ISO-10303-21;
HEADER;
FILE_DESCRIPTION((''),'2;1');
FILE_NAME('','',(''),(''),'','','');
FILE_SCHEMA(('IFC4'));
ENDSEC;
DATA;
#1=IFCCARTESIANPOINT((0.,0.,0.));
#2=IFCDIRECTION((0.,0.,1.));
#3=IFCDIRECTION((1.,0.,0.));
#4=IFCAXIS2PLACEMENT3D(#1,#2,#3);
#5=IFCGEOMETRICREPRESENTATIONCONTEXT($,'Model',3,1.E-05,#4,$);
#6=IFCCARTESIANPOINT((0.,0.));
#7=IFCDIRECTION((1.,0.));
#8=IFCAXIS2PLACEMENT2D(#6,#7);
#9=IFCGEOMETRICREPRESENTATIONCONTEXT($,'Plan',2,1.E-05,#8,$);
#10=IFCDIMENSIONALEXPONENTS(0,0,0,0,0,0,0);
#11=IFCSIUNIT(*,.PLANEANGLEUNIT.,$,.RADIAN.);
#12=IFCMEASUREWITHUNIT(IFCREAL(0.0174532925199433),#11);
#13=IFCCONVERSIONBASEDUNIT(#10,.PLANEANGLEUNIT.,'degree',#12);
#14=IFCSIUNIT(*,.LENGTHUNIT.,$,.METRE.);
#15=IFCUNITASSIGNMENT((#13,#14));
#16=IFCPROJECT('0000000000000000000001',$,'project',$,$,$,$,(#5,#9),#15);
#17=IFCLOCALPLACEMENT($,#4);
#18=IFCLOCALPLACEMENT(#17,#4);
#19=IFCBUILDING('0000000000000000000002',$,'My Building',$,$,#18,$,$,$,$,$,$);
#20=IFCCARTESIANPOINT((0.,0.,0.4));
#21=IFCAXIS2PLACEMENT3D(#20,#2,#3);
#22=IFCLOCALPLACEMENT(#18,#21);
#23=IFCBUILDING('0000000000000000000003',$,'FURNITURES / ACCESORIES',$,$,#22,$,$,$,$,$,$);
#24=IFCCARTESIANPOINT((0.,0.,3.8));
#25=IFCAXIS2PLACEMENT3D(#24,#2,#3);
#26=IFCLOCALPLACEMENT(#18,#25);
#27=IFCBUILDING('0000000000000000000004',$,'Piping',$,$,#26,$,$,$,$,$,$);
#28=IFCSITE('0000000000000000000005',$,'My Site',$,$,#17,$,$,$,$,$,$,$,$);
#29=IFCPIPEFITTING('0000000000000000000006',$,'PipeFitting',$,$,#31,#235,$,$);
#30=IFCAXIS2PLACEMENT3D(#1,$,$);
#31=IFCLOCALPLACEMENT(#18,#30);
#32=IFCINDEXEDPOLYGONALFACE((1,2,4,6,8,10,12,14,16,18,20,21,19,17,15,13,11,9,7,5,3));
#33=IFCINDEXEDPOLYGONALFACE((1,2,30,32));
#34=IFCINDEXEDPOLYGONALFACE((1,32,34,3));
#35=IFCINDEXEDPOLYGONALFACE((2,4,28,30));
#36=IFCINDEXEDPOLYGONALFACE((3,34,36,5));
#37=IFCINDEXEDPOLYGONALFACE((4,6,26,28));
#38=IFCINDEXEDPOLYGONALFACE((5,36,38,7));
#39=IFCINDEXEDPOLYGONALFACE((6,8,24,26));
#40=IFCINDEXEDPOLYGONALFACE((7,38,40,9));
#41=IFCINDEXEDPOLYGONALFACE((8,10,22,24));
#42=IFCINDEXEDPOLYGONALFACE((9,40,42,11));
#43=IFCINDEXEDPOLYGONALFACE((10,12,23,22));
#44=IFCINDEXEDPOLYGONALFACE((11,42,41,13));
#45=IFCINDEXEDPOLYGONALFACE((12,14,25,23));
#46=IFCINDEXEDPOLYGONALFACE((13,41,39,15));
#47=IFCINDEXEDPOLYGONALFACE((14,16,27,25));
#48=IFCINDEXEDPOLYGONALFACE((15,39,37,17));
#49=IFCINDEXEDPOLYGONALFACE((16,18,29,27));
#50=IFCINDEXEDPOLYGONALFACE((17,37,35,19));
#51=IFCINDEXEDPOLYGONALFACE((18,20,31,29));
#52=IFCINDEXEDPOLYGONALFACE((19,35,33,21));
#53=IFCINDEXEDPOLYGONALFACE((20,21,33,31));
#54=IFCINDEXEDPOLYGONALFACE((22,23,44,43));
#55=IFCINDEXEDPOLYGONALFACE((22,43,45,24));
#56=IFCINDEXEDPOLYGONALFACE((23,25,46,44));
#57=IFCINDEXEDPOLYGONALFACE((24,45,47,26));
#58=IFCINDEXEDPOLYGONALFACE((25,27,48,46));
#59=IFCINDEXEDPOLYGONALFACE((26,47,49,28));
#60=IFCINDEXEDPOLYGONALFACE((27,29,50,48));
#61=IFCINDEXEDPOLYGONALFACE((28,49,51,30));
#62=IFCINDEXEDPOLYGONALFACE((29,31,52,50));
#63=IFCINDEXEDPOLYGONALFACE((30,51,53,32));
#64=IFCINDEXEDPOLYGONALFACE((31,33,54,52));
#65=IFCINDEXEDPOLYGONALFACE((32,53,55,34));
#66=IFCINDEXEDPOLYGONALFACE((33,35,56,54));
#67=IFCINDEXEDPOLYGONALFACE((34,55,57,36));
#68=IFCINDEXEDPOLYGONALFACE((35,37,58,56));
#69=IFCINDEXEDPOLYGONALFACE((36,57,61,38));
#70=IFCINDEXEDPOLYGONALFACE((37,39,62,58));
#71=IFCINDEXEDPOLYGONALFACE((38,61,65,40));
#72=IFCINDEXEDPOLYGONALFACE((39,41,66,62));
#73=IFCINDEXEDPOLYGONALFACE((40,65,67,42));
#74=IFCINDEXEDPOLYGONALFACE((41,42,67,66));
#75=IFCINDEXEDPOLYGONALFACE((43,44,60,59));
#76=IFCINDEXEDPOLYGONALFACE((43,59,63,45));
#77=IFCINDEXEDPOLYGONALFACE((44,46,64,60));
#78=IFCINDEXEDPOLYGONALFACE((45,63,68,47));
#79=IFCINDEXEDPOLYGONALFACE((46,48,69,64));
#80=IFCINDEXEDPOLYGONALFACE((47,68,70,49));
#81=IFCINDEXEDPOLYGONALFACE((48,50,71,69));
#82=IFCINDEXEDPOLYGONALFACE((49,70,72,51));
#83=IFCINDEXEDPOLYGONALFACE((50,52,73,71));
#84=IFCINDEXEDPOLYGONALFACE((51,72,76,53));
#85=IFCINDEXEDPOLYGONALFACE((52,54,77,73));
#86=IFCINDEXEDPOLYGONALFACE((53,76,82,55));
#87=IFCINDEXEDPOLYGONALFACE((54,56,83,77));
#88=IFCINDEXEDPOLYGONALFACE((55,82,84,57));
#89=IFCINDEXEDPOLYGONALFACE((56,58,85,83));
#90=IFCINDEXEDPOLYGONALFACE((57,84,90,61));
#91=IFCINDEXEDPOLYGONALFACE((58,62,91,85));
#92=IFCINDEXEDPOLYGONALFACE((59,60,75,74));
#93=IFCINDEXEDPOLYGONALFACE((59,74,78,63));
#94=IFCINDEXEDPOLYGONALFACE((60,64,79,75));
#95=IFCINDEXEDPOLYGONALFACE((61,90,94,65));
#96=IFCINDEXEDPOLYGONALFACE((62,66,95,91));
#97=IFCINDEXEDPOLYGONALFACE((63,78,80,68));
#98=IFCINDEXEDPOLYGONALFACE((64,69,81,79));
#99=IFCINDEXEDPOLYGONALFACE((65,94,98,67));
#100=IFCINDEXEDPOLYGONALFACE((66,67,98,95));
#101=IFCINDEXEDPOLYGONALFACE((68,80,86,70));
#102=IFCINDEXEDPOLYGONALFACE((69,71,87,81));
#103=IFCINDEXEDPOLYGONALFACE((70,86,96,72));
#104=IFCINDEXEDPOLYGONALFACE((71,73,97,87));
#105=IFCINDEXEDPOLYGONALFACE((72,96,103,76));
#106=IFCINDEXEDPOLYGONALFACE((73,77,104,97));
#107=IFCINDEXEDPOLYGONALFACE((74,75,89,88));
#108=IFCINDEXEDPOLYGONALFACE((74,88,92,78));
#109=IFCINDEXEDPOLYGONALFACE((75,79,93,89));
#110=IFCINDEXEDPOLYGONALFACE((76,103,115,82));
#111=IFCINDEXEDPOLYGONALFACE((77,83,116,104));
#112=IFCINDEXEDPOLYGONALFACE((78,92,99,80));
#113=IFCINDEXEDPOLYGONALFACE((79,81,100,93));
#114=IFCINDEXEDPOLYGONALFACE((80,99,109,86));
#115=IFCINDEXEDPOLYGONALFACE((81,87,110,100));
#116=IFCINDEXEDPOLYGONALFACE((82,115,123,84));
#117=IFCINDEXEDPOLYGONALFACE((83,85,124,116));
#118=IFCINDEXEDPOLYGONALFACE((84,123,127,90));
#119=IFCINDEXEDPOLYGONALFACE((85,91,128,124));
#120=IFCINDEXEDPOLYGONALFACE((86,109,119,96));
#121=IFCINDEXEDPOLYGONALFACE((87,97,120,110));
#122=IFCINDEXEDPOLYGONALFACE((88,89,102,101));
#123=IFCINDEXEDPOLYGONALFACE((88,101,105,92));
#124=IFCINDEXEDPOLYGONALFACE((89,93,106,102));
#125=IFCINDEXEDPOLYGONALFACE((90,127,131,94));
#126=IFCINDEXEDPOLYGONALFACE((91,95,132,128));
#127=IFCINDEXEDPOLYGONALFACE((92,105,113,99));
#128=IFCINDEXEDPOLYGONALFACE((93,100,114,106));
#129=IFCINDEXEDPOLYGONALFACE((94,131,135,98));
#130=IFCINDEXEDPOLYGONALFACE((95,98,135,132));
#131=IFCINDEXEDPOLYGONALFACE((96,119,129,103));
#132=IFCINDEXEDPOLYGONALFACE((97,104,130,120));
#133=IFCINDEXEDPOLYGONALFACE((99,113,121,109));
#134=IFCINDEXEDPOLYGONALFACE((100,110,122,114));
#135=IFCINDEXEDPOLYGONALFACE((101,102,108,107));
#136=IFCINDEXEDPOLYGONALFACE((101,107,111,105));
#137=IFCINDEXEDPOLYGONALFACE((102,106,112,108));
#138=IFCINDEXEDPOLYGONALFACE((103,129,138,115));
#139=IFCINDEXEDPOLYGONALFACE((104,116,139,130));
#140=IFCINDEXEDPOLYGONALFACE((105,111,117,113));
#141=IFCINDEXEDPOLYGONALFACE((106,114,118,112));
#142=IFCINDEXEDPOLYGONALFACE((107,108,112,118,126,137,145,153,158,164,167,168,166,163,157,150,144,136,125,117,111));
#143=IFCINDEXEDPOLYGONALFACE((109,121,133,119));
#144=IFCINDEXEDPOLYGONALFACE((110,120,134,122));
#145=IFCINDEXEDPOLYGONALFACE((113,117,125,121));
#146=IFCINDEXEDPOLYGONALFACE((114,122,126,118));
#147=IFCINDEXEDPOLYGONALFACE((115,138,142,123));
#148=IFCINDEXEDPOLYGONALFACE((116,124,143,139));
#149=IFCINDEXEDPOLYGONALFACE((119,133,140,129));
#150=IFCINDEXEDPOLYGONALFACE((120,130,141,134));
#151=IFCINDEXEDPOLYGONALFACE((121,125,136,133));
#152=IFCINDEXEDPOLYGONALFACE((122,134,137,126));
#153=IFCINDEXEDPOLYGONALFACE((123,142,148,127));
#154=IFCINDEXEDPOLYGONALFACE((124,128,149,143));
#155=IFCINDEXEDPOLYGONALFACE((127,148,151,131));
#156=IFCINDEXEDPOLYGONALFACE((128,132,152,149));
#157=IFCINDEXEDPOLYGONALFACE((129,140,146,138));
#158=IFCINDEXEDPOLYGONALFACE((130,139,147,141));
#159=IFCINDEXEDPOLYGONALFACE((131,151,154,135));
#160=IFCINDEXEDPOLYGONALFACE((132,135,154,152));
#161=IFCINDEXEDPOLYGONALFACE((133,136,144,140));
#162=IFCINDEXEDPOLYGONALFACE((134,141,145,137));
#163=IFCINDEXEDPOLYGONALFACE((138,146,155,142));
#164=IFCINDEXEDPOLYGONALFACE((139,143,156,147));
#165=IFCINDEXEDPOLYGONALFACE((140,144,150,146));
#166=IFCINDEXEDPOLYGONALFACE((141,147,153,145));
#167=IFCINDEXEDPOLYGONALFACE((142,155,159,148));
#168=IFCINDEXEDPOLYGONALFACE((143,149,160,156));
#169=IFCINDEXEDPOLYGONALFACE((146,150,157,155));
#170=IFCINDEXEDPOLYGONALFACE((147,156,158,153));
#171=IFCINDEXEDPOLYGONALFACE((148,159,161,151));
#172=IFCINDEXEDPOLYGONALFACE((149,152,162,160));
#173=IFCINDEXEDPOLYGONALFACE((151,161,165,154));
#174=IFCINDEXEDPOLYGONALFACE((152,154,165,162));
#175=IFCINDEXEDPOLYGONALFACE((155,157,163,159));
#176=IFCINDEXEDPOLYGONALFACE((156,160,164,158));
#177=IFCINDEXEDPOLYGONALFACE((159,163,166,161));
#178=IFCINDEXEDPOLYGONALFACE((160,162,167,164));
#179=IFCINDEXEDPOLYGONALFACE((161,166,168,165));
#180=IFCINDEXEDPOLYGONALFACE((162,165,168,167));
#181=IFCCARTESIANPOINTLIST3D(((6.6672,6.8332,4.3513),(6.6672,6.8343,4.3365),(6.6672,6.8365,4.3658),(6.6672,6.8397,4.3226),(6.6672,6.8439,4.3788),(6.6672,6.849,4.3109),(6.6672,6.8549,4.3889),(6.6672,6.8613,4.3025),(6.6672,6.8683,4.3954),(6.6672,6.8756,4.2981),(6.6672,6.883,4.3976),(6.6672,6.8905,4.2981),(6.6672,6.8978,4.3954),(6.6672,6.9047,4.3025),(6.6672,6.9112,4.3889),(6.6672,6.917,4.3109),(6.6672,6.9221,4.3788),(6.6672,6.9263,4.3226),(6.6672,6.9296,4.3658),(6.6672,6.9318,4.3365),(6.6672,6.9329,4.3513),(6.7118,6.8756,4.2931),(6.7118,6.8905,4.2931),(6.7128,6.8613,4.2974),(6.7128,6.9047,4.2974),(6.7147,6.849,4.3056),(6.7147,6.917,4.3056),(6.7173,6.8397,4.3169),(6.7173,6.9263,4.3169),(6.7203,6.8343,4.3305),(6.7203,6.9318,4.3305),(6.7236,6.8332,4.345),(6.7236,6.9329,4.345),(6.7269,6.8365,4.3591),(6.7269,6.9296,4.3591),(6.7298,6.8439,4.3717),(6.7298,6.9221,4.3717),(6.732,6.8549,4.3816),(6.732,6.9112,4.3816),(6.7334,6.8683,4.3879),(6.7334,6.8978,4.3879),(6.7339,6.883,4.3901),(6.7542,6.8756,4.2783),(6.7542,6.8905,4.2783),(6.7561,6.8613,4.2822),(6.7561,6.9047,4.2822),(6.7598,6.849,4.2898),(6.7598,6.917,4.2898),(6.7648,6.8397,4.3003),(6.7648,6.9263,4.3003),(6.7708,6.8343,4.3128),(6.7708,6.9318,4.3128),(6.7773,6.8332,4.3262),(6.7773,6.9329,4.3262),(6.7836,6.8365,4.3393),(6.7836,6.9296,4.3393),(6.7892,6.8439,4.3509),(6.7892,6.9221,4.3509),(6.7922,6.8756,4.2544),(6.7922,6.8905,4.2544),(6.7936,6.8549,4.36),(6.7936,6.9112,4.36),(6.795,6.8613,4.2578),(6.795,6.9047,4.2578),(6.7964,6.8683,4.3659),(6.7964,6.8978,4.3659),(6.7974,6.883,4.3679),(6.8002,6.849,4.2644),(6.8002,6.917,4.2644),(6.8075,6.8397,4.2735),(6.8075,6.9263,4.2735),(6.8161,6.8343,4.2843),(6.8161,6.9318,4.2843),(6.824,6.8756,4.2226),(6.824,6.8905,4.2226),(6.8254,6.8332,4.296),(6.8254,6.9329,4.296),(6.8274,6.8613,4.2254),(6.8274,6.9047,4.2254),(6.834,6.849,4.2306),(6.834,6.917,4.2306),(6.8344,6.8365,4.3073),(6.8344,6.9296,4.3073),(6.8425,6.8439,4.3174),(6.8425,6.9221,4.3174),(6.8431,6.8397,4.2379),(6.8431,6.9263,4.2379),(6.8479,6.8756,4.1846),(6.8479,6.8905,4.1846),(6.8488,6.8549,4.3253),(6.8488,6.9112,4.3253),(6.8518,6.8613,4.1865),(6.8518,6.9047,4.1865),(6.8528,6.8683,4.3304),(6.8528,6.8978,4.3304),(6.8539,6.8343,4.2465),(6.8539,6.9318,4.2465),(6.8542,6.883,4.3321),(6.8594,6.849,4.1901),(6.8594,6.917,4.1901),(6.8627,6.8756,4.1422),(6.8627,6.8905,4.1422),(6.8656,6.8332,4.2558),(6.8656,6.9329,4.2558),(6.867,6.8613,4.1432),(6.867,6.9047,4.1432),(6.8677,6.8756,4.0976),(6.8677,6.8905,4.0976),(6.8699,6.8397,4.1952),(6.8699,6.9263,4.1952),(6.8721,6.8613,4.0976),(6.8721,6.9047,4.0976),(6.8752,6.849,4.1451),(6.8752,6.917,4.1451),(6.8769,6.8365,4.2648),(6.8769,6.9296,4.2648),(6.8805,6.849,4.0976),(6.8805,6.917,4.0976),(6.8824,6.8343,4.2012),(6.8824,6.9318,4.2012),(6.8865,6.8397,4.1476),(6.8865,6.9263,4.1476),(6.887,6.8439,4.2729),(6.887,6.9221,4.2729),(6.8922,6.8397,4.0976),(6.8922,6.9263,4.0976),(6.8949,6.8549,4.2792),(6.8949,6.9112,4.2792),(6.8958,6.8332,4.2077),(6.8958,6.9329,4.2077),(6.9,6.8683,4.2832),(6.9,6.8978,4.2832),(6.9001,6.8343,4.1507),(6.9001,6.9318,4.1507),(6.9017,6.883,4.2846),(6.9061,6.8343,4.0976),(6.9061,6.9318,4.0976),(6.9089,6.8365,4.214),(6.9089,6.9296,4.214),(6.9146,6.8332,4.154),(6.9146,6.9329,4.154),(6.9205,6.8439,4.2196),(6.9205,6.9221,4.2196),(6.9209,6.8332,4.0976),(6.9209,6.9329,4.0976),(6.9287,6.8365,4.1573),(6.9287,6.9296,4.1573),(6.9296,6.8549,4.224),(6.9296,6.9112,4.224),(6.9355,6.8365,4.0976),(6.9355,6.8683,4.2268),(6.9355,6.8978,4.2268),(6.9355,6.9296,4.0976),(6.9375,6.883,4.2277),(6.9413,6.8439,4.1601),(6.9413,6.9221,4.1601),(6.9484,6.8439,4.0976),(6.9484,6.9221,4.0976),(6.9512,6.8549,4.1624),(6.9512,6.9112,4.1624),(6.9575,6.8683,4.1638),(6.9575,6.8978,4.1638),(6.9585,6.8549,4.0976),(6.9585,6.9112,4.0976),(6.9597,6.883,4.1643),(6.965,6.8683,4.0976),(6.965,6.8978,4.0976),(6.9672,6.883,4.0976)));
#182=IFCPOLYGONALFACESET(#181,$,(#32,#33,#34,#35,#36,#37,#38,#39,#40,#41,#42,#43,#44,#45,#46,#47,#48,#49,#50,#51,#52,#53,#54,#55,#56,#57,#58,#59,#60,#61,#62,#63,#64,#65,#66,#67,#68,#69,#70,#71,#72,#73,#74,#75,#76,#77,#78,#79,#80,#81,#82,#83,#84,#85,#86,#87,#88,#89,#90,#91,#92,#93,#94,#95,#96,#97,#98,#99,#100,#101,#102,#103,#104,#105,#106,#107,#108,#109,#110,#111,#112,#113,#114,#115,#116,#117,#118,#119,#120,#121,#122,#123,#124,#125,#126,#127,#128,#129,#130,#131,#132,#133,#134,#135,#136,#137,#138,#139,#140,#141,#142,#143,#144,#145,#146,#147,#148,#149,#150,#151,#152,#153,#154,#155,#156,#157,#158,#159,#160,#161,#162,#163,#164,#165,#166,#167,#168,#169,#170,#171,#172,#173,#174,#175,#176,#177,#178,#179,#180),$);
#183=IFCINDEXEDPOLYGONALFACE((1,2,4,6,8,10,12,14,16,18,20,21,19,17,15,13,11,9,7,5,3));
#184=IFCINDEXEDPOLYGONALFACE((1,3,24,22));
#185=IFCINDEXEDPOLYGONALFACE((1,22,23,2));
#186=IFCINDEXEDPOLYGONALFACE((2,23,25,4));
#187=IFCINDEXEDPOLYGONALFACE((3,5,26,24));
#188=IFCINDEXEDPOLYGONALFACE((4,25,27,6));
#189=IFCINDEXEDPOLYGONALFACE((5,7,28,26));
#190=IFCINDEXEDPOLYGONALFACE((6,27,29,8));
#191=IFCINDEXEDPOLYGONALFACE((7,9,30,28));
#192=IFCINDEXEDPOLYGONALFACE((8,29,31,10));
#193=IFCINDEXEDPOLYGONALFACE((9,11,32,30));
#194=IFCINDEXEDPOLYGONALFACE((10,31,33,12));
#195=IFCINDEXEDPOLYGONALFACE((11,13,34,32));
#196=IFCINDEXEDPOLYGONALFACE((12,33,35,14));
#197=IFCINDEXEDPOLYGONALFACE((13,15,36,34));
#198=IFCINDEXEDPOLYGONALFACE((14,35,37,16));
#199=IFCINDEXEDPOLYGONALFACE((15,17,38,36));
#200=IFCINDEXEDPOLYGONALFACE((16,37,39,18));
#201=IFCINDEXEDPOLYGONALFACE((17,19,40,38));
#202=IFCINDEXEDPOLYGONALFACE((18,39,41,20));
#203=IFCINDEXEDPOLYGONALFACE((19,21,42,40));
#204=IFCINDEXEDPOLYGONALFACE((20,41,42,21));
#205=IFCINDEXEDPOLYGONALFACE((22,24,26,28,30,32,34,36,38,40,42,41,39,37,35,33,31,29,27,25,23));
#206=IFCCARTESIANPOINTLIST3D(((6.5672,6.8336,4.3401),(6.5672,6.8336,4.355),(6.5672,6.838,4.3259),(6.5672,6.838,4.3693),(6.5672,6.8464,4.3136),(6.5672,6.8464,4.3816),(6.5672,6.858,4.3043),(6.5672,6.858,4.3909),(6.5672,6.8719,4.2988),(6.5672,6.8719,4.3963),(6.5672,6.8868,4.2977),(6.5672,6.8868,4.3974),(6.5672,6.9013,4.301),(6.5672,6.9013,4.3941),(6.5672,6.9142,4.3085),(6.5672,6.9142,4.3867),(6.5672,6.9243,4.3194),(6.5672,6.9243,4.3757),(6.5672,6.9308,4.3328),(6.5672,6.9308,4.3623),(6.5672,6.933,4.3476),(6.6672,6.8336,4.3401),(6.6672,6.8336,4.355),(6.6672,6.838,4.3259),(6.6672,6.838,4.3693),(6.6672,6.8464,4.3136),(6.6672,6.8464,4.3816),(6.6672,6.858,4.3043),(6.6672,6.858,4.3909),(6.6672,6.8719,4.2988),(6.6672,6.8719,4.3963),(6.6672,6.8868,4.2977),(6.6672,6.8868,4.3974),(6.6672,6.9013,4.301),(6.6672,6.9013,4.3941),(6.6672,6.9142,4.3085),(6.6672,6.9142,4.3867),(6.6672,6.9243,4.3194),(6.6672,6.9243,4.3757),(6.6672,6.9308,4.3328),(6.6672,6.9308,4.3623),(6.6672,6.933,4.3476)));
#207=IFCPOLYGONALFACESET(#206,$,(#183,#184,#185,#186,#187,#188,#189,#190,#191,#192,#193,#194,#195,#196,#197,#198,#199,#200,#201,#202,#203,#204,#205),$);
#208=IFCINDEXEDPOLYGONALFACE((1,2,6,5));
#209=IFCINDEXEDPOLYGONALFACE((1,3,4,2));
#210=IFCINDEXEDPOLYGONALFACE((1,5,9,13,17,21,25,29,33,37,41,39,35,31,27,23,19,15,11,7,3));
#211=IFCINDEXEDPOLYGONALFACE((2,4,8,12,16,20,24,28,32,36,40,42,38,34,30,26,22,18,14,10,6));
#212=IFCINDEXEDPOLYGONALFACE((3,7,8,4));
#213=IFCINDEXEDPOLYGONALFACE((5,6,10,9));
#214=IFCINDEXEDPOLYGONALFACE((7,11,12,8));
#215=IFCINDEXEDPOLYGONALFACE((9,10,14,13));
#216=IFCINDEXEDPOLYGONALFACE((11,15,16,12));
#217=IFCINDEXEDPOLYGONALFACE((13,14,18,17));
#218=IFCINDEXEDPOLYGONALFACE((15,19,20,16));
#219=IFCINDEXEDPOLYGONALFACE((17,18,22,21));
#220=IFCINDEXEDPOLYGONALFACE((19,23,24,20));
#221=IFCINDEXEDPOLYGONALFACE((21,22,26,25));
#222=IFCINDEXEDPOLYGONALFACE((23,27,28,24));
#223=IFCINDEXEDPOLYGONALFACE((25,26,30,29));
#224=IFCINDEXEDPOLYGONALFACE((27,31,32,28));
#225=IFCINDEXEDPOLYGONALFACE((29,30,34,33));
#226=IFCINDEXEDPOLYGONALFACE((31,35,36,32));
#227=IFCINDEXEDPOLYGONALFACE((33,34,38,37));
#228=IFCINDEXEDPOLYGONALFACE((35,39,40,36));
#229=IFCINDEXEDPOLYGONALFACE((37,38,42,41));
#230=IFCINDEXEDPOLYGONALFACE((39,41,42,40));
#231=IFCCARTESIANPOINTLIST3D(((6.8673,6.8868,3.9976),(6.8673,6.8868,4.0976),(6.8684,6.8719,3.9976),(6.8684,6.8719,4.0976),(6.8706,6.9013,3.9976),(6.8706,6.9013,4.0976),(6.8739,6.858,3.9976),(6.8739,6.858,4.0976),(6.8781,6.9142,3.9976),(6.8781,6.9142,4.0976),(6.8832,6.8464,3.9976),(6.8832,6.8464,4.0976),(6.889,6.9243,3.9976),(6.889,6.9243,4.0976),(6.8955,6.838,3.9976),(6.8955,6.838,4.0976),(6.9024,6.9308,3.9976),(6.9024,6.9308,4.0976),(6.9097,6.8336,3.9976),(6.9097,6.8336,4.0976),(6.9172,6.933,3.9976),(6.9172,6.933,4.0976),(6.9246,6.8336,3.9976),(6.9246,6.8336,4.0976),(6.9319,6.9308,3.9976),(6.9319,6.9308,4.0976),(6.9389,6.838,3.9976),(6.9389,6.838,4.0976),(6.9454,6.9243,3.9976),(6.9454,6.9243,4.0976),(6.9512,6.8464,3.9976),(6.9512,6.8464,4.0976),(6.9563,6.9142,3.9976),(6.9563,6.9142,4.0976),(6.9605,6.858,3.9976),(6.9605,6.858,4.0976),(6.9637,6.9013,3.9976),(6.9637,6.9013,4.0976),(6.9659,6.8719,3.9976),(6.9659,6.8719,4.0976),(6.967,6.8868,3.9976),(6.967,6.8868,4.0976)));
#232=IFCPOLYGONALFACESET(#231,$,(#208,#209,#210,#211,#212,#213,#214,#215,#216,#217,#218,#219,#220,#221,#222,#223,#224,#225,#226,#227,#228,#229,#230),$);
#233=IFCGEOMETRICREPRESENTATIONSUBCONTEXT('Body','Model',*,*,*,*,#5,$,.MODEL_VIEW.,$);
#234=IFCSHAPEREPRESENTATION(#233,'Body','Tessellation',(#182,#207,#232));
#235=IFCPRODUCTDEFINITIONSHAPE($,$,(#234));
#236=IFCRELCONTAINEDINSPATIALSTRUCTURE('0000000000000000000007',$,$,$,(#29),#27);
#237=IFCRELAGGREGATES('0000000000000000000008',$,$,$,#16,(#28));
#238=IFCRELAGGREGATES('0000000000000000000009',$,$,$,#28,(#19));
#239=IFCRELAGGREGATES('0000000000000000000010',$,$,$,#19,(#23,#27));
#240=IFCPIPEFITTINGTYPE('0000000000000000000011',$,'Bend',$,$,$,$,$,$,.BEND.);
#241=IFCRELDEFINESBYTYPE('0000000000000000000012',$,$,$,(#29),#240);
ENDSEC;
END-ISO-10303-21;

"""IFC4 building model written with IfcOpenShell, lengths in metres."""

from ifc_helpers import new_model, entity, si_unit, converted_unit, frame, origin_with_axes, origin_2d_with_axis, place, context, subcontext, project, spatial, circle, extrude, source, transform, mapped, type_object, type_shapes, element, save


model = new_model("IFC4")

# Units and contexts
model_context = context("Model", 3, precision=1e-05, world=origin_with_axes())
plan_context = context("Plan", 2, precision=1e-05, world=origin_2d_with_axis())
body_context = subcontext(model_context, "Body", "Model", "MODEL_VIEW")
ifc_project = project(units=[converted_unit("PLANEANGLEUNIT", "degree", entity("IfcReal", 0.0174532925199433), si_unit("PLANEANGLEUNIT", "RADIAN"), dimensions=[0, 0, 0, 0, 0, 0, 0]), si_unit("LENGTHUNIT", "METRE")], contexts=[model_context, plan_context])

# Site, building
site_placement = place(None, origin_with_axes())
site = spatial("IfcSite", under=ifc_project, at=site_placement, Name="My Site")
building_1_placement = place(site_placement, origin_with_axes())
building_1 = spatial("IfcBuilding", under=site, at=building_1_placement, Name="My Building")

# Shared definitions
building_2_placement = place(building_1_placement, frame((0.0, 0.0, 0.4), z_axis=(0.0, 0.0, 1.0), x_axis=(1.0, 0.0, 0.0)))
building_2 = spatial("IfcBuilding", under=building_1, at=building_2_placement, Name="FURNITURES / ACCESORIES")

# Shared definitions
building_3_placement = place(building_1_placement, frame((0.0, 0.0, 3.8), z_axis=(0.0, 0.0, 1.0), x_axis=(1.0, 0.0, 0.0)))
building_3 = spatial("IfcBuilding", under=building_1, at=building_3_placement, Name="Piping")

# Pipe fitting
pipe_fitting_type = type_object("IfcPipeFittingType", Name="Bend", PredefinedType="BEND")
shared_shape = source(origin_with_axes(), body_context, "Body", "SolidModel", [
    entity("IfcSweptDiskSolid", entity("IfcIndexedPolyCurve", entity("IfcCartesianPointList3D", [[0.0, 0.0, 0.1], [0.0, -0.0732, 0.2768], [0.0, -0.25, 0.35]]), [entity("IfcArcIndex", [1, 2, 3])]), 0.05),
    extrude(circle(Radius=0.05), origin_with_axes(), (0.0, 0.0, 1.0), 0.1),
    extrude(circle(Radius=0.05), frame((0.0, -0.25, 0.35), z_axis=(0.0, -1.0, -0.000001), x_axis=(1.0, 0.0, 0.0)), (0.0, 0.0, 1.0), 0.1),
])
type_shapes(pipe_fitting_type, [shared_shape])
for number, where, z_axis, x_axis, name in (
    (1, (6.5672, 6.883, 0.5476), (1.0, -0.000001, 0.000001), (0.000001, 1.0, 0.0), "PipeFitting"),
):
    element("IfcPipeFitting", number, at=place(building_3_placement, frame(where, z_axis=z_axis, x_axis=x_axis)), inside=building_3, type_object=pipe_fitting_type, Name=name, context=body_context, shape_type="MappedRepresentation", body=[
        mapped(shared_shape, transform((0.0, 0.0, 0.0), x_axis=(1.0, 0.0, 0.0), y_axis=(0.0, 1.0, 0.0), z_axis=(0.0, 0.0, 1.0), scale=1.0)),
    ])

save(model, "model.ifc")
